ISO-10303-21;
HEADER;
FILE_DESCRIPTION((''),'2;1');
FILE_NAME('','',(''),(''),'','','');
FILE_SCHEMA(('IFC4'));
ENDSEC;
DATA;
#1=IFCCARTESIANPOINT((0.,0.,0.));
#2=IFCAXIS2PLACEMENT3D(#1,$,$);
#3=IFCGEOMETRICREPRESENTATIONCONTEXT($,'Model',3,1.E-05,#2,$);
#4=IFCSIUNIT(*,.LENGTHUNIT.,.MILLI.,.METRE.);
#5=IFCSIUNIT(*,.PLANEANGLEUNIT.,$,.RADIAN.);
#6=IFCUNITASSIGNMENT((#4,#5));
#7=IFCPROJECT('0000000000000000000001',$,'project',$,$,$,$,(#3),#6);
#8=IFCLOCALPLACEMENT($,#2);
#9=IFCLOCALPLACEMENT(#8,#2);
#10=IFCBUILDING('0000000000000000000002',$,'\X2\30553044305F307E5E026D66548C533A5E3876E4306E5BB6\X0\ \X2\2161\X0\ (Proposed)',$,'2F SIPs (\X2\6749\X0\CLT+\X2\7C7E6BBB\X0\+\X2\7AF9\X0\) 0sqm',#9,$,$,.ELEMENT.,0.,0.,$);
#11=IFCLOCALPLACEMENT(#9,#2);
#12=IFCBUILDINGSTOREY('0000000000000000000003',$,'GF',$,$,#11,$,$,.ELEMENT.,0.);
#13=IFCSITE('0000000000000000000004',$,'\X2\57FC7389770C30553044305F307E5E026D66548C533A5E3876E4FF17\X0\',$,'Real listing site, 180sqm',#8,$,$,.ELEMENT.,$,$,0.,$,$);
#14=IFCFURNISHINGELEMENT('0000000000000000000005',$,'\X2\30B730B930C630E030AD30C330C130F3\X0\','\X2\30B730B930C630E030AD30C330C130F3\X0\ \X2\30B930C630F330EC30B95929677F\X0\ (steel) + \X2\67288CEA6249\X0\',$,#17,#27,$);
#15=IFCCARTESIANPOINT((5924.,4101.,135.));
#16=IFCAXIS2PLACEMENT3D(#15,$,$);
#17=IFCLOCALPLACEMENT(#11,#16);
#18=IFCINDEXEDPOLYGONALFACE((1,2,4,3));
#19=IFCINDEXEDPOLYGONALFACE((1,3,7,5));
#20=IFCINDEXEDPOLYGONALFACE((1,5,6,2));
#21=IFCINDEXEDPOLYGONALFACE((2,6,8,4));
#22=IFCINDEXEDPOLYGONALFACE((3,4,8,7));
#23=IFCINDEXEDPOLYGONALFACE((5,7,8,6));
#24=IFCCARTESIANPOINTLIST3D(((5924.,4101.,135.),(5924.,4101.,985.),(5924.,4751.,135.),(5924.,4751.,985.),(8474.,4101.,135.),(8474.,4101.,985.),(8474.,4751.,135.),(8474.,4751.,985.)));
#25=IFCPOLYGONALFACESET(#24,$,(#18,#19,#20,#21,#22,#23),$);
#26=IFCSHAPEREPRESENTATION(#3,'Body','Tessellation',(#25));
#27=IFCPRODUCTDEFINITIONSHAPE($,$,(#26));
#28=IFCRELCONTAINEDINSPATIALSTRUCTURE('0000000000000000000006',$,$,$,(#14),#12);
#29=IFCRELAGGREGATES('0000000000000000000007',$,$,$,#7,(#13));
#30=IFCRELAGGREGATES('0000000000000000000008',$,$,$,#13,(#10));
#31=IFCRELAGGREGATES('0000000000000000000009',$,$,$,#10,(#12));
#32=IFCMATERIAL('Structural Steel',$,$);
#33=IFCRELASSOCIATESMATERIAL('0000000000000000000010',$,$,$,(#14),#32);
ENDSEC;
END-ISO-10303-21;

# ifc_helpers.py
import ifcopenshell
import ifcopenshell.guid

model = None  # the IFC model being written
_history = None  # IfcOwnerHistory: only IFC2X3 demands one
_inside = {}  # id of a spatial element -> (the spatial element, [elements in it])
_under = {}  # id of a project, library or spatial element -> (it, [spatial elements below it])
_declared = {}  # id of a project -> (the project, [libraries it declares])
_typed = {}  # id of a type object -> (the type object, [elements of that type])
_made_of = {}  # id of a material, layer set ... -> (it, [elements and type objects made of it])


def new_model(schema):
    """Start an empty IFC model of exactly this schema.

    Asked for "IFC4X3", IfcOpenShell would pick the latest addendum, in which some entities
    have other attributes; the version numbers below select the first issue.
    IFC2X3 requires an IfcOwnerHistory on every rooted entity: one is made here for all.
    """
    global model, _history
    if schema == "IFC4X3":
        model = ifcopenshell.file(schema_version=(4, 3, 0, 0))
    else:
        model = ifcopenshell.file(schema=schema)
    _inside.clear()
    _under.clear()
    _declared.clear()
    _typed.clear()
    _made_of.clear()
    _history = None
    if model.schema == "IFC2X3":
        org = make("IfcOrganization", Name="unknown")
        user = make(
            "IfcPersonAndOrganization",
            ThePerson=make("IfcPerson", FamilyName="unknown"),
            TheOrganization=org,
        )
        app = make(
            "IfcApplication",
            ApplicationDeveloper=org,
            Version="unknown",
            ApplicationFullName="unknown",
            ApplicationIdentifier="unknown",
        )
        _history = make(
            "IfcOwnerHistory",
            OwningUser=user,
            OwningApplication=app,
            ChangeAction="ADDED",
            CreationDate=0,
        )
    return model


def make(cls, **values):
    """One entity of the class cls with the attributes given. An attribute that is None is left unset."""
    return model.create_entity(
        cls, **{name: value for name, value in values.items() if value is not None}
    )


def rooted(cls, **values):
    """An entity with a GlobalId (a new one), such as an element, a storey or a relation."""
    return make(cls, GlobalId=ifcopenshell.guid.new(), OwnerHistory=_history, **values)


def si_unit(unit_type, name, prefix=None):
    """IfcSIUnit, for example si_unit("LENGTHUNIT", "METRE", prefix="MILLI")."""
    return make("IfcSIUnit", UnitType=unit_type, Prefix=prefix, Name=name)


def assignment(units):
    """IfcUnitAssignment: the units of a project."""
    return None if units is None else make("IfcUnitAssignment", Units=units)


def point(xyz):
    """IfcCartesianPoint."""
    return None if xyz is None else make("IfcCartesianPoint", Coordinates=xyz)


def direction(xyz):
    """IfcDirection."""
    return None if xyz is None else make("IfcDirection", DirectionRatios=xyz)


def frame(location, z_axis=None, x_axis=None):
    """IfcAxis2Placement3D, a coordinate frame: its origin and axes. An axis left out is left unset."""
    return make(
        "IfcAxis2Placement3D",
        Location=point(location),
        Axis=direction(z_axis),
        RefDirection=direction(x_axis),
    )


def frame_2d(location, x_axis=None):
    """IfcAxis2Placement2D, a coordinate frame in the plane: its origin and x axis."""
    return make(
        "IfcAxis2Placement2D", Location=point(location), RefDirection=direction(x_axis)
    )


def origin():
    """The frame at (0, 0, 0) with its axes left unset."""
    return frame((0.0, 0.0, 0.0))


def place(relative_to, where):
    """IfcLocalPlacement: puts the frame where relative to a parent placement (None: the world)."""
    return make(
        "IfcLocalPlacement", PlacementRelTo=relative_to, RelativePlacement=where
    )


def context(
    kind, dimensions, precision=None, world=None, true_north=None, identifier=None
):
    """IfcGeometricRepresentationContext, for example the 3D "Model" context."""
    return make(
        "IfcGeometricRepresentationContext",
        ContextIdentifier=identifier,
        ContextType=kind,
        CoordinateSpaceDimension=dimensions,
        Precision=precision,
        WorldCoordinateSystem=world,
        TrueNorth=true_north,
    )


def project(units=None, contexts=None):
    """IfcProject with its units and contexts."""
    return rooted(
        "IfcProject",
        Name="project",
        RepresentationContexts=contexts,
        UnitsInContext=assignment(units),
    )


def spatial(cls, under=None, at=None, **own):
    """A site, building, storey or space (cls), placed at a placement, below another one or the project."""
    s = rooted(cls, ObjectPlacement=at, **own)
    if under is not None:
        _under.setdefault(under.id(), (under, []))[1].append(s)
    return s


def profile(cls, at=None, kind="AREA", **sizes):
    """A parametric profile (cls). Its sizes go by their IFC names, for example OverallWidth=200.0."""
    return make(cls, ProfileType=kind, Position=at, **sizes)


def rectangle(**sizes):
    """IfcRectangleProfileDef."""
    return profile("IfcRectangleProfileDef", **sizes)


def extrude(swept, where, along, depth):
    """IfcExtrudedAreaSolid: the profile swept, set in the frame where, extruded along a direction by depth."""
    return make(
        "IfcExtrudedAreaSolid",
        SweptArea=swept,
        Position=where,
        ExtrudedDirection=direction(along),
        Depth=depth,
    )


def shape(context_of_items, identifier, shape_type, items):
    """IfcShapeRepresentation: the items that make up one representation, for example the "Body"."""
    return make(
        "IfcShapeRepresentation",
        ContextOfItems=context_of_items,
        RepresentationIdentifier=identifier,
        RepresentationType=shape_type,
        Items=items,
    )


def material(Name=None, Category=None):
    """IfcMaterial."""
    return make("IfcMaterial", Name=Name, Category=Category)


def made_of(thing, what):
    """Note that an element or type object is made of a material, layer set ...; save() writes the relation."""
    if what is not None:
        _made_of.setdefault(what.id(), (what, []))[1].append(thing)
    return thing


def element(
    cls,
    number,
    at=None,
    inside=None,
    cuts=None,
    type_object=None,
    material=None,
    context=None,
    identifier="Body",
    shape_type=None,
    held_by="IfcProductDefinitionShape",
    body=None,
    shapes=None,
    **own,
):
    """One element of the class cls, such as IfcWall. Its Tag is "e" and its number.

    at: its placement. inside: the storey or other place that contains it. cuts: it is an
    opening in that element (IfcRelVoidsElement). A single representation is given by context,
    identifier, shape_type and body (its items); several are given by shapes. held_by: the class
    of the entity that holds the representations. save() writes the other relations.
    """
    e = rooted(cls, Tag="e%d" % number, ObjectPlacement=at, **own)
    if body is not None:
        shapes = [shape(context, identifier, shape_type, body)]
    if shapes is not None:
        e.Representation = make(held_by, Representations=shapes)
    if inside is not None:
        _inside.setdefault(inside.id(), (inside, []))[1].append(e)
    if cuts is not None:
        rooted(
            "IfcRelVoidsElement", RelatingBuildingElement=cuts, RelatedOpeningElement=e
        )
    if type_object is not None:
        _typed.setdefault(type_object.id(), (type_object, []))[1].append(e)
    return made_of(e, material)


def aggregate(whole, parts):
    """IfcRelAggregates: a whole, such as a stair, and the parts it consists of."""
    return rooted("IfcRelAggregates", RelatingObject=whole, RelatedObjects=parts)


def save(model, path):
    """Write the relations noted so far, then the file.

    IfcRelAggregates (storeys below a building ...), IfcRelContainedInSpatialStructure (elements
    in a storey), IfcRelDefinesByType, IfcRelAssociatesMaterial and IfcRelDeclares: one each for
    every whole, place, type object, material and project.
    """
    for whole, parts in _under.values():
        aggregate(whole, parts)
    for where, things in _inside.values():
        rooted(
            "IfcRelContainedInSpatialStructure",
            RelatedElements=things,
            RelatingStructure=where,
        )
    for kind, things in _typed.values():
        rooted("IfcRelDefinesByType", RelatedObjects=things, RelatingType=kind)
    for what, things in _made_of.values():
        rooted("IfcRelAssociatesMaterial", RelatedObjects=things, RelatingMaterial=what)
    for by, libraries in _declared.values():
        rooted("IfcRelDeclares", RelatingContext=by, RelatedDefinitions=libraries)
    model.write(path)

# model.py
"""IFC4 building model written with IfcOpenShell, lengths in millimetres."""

from ifc_helpers import new_model, si_unit, frame, frame_2d, origin, place, context, project, spatial, rectangle, extrude, material, element, save


model = new_model("IFC4")

# Units and contexts
model_context = context("Model", 3, precision=1e-05, world=origin())
ifc_project = project(units=[si_unit("LENGTHUNIT", "METRE", prefix="MILLI"), si_unit("PLANEANGLEUNIT", "RADIAN")], contexts=[model_context])

# Site, building, storey
site_placement = place(None, origin())
site = spatial("IfcSite", under=ifc_project, at=site_placement, Name="埼玉県さいたま市浦和区常盤７", ObjectType="Real listing site, 180sqm", CompositionType="ELEMENT", RefElevation=0.0)
building_placement = place(site_placement, origin())
building = spatial("IfcBuilding", under=site, at=building_placement, Name="さいたま市浦和区常盤の家 Ⅱ (Proposed)", ObjectType="2F SIPs (杉CLT+籾殻+竹) 0sqm", CompositionType="ELEMENT", ElevationOfRefHeight=0.0, ElevationOfTerrain=0.0)
storey_placement = place(building_placement, origin())
storey = spatial("IfcBuildingStorey", under=building, at=storey_placement, Name="GF", CompositionType="ELEMENT", Elevation=0.0)

# Furnishing element
ifc_material_1 = material(Name="Structural Steel")
furnishing_placement = place(storey_placement, frame((5924.0, 4101.0, 135.0)))
element("IfcFurnishingElement", 1, at=furnishing_placement, inside=storey, material=ifc_material_1, Name="システムキッチン", Description="システムキッチン ステンレス天板 (steel) + 木質扉", context=model_context, shape_type="SweptSolid", body=[
    extrude(rectangle(XDim=2550.0, YDim=650.0, at=frame_2d((1275.0, 325.0))), frame((5924.0, 4101.0, 135.0)), (0.0, 0.0, 1.0), 850.0),
])

save(model, "model.ifc")
